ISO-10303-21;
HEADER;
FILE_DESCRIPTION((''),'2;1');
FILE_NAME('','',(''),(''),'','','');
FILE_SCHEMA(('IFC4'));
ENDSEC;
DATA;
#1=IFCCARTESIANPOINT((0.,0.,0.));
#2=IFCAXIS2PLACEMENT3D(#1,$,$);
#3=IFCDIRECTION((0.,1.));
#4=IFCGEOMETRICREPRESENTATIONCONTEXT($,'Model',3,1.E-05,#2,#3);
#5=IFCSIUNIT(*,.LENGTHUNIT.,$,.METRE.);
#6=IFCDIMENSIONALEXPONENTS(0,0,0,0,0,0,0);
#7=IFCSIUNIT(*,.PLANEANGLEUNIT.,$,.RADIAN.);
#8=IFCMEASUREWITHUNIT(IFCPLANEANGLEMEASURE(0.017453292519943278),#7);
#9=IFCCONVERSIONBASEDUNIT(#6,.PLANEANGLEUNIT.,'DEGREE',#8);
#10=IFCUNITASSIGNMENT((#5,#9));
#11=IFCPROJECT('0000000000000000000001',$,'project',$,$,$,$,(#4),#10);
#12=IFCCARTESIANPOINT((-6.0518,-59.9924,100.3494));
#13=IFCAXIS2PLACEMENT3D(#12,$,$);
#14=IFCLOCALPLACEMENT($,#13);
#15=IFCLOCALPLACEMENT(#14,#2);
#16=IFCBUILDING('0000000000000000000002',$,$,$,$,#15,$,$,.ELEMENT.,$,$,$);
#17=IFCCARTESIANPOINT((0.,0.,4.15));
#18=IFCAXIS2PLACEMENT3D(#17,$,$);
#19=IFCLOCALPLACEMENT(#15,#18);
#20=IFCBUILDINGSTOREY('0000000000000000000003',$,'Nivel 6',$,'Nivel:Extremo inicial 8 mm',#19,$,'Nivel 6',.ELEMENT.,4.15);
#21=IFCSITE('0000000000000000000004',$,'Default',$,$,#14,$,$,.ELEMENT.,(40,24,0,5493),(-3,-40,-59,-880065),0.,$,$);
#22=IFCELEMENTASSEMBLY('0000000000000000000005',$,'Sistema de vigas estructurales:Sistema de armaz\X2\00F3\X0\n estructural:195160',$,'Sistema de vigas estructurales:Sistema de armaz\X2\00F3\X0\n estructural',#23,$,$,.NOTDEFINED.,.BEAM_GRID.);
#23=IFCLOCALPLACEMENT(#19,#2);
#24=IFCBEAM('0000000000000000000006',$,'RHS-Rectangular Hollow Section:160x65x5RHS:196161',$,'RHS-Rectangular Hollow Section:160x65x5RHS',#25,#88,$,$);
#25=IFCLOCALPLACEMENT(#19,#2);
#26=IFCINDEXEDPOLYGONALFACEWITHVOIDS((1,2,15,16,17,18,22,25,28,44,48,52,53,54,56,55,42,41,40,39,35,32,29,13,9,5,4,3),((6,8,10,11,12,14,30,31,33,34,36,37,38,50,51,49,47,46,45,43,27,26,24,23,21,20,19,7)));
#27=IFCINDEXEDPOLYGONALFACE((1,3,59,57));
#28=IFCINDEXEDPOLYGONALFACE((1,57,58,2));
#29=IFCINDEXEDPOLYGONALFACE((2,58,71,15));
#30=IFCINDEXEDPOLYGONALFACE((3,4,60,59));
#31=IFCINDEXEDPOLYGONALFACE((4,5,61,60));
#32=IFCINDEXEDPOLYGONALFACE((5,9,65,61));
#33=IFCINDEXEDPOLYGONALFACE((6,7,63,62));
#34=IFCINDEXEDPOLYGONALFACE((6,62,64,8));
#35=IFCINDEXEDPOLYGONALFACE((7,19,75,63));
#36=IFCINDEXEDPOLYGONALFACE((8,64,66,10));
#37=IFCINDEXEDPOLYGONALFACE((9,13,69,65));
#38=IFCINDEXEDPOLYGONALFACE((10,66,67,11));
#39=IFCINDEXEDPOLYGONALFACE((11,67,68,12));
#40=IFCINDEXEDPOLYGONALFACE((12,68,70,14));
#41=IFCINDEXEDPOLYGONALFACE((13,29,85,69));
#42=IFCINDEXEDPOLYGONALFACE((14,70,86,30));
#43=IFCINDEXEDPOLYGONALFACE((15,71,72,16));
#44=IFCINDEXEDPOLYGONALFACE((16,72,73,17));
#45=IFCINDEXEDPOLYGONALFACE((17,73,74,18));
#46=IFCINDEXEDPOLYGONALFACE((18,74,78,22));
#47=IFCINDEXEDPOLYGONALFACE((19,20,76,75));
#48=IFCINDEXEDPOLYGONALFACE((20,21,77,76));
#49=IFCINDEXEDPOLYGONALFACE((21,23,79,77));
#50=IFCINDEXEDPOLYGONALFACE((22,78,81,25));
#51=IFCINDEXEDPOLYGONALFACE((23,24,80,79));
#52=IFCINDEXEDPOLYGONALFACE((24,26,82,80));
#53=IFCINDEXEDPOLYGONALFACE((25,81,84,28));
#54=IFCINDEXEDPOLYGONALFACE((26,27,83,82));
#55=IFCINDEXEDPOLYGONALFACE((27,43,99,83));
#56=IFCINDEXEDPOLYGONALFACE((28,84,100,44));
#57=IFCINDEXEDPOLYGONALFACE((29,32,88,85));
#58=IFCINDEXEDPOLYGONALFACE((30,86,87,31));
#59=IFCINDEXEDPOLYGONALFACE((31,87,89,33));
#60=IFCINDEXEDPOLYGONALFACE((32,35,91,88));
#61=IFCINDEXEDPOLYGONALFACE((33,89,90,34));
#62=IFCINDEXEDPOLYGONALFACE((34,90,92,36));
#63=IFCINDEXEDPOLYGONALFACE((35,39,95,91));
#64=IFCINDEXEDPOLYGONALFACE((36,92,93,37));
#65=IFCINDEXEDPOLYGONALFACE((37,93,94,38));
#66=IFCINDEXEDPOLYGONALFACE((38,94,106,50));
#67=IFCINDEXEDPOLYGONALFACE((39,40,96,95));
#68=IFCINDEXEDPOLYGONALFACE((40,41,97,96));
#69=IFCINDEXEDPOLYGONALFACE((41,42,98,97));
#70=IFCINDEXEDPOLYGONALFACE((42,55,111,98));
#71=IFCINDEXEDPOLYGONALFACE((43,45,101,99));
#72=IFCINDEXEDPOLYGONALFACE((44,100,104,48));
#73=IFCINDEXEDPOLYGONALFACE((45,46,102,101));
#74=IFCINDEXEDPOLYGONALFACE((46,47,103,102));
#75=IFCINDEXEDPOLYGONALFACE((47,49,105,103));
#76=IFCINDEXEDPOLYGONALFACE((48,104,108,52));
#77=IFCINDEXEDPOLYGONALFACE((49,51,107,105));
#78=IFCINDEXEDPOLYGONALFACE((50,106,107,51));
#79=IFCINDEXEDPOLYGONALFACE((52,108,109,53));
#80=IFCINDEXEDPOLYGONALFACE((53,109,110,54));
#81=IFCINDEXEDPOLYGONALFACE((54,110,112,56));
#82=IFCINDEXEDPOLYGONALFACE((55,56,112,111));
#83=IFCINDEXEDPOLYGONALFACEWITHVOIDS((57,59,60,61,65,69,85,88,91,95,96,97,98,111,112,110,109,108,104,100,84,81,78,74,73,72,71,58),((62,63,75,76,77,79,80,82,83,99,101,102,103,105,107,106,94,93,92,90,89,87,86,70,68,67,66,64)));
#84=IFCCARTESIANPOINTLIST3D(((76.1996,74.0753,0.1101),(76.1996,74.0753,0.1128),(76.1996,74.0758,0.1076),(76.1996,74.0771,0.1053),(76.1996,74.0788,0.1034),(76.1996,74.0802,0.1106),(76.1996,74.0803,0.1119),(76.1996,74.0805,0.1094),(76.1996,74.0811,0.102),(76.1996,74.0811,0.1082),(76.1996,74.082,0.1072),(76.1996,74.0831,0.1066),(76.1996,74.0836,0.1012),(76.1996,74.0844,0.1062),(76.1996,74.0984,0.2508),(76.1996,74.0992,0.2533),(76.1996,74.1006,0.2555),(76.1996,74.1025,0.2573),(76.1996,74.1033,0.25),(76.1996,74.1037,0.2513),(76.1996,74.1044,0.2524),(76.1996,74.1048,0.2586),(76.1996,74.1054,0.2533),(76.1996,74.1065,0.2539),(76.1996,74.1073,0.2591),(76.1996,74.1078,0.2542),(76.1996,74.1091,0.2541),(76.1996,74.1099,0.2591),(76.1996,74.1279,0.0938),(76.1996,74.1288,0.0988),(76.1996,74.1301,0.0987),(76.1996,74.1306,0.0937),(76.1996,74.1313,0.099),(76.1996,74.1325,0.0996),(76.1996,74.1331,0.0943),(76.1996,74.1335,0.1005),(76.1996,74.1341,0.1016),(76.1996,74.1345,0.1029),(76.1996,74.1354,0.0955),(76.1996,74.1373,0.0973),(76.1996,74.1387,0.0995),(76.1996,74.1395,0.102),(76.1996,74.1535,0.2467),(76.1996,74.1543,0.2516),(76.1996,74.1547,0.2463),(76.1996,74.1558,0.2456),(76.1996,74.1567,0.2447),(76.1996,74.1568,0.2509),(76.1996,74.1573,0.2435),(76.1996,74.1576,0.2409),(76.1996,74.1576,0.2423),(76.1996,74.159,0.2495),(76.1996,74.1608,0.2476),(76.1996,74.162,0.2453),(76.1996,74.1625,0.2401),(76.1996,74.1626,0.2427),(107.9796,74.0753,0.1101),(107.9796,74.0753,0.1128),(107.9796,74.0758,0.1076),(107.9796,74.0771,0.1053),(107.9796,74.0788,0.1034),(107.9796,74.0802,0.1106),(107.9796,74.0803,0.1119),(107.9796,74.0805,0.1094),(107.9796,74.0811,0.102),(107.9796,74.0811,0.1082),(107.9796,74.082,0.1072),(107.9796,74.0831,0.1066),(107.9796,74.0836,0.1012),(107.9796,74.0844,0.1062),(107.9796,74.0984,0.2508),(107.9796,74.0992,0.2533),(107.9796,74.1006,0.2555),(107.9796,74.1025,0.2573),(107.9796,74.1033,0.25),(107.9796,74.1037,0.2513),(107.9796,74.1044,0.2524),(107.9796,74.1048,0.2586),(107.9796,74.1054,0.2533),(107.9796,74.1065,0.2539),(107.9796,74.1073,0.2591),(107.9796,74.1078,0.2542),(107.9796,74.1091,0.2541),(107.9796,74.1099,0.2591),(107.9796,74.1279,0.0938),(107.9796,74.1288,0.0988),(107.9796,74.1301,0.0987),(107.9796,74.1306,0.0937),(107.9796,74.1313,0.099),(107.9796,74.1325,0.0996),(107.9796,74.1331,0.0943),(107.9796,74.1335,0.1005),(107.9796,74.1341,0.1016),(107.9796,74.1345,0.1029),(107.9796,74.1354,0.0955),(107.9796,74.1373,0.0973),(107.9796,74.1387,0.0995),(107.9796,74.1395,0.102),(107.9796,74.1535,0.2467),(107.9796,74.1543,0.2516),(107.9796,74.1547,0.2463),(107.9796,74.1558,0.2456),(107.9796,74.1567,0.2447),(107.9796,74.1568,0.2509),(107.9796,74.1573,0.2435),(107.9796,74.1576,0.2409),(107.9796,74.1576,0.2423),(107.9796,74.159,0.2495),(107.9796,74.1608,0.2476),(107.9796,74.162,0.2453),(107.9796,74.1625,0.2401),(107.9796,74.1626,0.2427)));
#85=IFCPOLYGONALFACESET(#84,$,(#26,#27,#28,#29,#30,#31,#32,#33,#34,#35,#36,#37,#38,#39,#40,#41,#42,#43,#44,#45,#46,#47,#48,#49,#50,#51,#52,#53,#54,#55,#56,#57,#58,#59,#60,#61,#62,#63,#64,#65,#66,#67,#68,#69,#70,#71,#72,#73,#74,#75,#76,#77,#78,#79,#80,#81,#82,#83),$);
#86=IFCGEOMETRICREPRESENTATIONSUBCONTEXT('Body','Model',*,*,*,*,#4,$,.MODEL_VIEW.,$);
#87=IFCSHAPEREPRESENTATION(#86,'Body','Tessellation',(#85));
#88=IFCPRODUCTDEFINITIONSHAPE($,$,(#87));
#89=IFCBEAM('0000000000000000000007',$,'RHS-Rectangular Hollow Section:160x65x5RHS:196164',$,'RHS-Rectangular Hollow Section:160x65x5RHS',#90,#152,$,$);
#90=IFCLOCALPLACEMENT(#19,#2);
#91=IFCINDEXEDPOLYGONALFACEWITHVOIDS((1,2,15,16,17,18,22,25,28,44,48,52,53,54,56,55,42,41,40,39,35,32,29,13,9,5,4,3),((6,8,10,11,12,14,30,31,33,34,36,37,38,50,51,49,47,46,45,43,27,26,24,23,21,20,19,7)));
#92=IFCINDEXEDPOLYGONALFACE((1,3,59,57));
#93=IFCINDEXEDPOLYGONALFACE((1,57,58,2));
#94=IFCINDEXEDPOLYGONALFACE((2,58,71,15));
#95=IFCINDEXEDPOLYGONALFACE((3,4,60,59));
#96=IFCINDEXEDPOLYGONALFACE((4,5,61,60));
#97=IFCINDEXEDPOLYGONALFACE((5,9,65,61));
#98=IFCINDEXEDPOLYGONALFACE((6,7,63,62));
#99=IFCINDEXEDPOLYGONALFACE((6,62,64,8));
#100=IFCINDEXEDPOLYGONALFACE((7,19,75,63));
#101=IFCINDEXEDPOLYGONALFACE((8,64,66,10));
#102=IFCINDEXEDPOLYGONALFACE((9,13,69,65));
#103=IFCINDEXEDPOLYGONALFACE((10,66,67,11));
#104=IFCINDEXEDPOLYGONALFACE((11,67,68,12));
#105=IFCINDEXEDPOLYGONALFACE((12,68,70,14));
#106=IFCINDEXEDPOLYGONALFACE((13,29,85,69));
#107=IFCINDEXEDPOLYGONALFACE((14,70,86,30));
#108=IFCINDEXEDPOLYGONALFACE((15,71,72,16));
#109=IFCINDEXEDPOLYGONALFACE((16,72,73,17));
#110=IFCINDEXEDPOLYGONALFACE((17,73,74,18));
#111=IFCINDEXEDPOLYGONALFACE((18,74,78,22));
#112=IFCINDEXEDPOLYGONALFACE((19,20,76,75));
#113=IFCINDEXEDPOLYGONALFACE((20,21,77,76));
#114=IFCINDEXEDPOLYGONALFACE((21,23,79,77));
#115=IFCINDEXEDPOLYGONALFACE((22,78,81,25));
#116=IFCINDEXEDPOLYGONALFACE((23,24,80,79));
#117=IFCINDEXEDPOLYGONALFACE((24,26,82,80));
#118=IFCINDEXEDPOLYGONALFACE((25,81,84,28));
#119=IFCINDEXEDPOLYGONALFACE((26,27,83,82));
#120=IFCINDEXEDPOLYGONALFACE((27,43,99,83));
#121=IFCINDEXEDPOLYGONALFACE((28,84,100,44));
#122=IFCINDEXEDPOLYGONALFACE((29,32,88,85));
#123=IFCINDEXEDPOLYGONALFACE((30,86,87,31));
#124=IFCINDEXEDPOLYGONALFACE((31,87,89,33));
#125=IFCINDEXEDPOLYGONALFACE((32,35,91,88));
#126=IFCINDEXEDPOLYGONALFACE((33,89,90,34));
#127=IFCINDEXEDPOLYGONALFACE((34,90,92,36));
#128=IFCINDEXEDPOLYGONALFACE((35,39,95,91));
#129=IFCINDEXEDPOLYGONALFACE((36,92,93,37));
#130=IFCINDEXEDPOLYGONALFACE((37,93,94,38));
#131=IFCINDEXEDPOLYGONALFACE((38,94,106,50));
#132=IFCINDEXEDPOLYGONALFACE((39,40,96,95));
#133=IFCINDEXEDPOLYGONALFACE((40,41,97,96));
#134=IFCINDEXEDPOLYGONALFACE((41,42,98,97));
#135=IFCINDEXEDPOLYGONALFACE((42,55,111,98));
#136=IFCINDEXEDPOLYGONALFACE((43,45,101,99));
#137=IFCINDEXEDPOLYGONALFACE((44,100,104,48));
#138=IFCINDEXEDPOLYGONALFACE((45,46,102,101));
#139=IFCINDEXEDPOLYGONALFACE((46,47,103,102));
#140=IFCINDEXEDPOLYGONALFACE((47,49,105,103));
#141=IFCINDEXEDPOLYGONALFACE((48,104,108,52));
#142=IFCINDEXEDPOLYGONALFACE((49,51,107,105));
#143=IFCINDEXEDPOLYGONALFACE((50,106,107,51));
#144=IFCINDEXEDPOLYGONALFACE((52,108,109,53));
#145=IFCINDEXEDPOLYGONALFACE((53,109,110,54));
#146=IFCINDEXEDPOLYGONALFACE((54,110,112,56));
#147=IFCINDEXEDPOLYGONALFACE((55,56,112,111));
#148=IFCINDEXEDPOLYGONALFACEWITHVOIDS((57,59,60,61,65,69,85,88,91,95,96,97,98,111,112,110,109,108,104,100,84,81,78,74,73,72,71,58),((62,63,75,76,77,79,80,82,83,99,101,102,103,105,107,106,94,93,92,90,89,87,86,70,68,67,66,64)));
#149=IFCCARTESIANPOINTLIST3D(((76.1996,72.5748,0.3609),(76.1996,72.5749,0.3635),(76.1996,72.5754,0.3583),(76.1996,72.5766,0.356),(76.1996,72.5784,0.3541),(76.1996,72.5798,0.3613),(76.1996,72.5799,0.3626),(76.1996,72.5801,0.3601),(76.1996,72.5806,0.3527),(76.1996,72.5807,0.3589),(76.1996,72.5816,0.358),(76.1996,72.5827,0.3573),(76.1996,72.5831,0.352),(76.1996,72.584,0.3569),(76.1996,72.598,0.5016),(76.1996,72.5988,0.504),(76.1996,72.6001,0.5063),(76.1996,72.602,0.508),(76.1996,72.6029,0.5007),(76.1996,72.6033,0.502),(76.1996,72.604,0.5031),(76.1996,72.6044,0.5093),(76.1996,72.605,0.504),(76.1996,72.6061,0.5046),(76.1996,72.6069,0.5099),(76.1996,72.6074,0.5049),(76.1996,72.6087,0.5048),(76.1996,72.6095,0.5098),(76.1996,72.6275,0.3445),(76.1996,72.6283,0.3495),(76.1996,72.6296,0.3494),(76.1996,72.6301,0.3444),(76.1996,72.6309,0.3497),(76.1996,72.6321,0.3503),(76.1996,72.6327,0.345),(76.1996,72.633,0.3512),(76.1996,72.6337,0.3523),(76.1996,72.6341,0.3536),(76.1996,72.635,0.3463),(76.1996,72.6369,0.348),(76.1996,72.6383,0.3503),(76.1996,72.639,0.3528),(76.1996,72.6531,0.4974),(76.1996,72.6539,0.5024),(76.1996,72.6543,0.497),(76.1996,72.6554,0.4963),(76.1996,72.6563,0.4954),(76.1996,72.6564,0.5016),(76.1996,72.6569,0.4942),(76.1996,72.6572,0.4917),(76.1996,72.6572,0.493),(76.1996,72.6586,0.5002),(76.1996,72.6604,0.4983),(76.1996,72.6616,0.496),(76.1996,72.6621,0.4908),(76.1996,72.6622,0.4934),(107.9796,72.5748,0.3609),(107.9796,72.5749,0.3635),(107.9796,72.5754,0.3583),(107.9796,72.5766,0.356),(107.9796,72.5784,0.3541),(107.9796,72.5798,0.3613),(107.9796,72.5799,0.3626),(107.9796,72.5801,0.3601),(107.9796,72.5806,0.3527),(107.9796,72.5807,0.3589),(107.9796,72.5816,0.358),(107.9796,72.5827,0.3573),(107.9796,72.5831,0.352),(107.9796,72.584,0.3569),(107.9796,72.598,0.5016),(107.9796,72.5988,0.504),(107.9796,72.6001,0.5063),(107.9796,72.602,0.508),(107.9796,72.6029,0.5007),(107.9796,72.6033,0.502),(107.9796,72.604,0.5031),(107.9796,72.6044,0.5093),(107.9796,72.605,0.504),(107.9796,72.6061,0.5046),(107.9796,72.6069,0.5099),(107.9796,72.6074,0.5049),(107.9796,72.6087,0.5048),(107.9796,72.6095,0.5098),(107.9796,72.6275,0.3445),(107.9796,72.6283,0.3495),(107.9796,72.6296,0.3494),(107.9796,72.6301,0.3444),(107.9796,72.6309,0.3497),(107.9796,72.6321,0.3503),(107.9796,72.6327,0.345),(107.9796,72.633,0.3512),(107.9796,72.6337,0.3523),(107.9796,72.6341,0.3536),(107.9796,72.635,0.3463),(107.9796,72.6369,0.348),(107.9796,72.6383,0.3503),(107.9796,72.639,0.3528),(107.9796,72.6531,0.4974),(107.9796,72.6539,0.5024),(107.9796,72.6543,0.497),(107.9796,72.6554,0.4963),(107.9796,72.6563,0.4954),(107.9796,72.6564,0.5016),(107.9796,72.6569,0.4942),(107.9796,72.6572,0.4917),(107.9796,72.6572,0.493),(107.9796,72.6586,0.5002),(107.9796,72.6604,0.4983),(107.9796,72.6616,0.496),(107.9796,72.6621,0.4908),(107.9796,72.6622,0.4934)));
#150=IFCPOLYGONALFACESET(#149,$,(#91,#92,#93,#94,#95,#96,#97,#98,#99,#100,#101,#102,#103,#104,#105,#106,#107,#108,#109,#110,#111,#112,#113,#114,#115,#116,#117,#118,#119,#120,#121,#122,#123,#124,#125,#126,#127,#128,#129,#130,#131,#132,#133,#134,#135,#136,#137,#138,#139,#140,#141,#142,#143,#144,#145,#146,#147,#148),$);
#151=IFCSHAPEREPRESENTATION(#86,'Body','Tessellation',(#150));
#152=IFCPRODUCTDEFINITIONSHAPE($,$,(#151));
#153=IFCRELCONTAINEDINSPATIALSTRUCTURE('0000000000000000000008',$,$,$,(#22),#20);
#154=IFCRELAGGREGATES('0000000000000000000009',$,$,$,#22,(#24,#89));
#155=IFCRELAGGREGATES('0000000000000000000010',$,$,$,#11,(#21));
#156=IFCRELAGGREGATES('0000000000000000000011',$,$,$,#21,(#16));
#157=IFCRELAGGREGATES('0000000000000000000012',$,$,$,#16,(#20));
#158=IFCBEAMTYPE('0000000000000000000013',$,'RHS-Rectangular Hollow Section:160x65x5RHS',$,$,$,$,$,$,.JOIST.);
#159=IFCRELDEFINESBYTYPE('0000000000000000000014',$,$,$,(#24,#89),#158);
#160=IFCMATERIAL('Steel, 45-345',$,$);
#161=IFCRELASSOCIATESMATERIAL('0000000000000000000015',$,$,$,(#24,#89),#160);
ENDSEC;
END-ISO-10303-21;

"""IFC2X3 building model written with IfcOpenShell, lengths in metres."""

from ifc_helpers import new_model, entity, si_unit, converted_unit, direction, frame, frame_2d, origin, place, context, subcontext, project, spatial, polyline, circle_curve, parameter, trimmed, segment, composite_curve, outline, extrude, material, type_object, element, aggregate, save


model = new_model("IFC2X3")

# Units and contexts
model_context = context("Model", 3, precision=1e-05, world=origin(), true_north=direction((0.0, 1.0)))
body_context = subcontext(model_context, "Body", "Model", "MODEL_VIEW")
ifc_project = project(units=[si_unit("LENGTHUNIT", "METRE"), converted_unit("PLANEANGLEUNIT", "DEGREE", entity("IfcPlaneAngleMeasure", 0.017453292519943278), si_unit("PLANEANGLEUNIT", "RADIAN"), dimensions=[0, 0, 0, 0, 0, 0, 0])], contexts=[model_context])

# Site, building, storey
site_placement = place(None, frame((-6.0518, -59.9924, 100.3494)))
site = spatial("IfcSite", under=ifc_project, at=site_placement, Name="Default", CompositionType="ELEMENT", RefLatitude=(40, 24, 0, 5493), RefLongitude=(-3, -40, -59, -880065), RefElevation=0.0)
building_placement = place(site_placement, origin())
building = spatial("IfcBuilding", under=site, at=building_placement, CompositionType="ELEMENT")
storey_placement = place(building_placement, frame((0.0, 0.0, 4.15)))
storey = spatial("IfcBuildingStorey", under=building, at=storey_placement, Name="Nivel 6", ObjectType="Nivel:Extremo inicial 8 mm", LongName="Nivel 6", CompositionType="ELEMENT", Elevation=4.15)

# Shared definitions
ifc_material_1 = material(Name="Steel, 45-345")

# Element assembly, beams
assembly_placement = place(storey_placement, origin())
assembly = element("IfcElementAssembly", 1, at=assembly_placement, inside=storey, Name="Sistema de vigas estructurales:Sistema de armazón estructural:195160", ObjectType="Sistema de vigas estructurales:Sistema de armazón estructural", AssemblyPlace="NOTDEFINED", PredefinedType="BEAM_GRID")
beam_type_1 = type_object("IfcBeamType", Name="RHS-Rectangular Hollow Section:160x65x5RHS", PredefinedType="JOIST")
beam_1_placement = place(assembly_placement, frame((107.9796, 74.0794, -0.0603), z_axis=(0.0, 0.0, 1.0), x_axis=(-1.0, 0.0, 0.0)))
beam_1 = element("IfcBeam", 2, at=beam_1_placement, type_object=beam_type_1, material=ifc_material_1, Name="RHS-Rectangular Hollow Section:160x65x5RHS:196161", ObjectType="RHS-Rectangular Hollow Section:160x65x5RHS", context=body_context, shape_type="SweptSolid", body=[
    extrude(outline(composite_curve([segment(trimmed(circle_curve(frame_2d((-0.0225, -0.07), x_axis=(1.0, 0.0)), 0.01), [parameter(180.0)], [parameter(270.0)], True, "PARAMETER"), True, "CONTINUOUS"), segment(polyline([(-0.0225, -0.08), (0.0225, -0.08)]), True, "CONTINUOUS"), segment(trimmed(circle_curve(frame_2d((0.0225, -0.07), x_axis=(1.0, 0.0)), 0.01), [parameter(270.0)], [parameter(0.0)], True, "PARAMETER"), True, "CONTINUOUS"), segment(polyline([(0.0325, -0.07), (0.0325, 0.07)]), True, "CONTINUOUS"), segment(trimmed(circle_curve(frame_2d((0.0225, 0.07), x_axis=(1.0, 0.0)), 0.01), [parameter(360.0)], [parameter(90.0)], True, "PARAMETER"), True, "CONTINUOUS"), segment(polyline([(0.0225, 0.08), (-0.0225, 0.08)]), True, "CONTINUOUS"), segment(trimmed(circle_curve(frame_2d((-0.0225, 0.07), x_axis=(1.0, 0.0)), 0.01), [parameter(90.0)], [parameter(180.0)], True, "PARAMETER"), True, "CONTINUOUS"), segment(polyline([(-0.0325, 0.07), (-0.0325, -0.07)]), True, "CONTINUOUS")], self_intersect=False), holes=[composite_curve([segment(polyline([(0.0225, -0.075), (-0.0225, -0.075)]), True, "CONTINUOUS"), segment(trimmed(circle_curve(frame_2d((-0.0225, -0.07), x_axis=(1.0, 0.0)), 0.005), [parameter(180.0)], [parameter(270.0)], True, "PARAMETER"), False, "CONTINUOUS"), segment(polyline([(-0.0275, -0.07), (-0.0275, 0.07)]), True, "CONTINUOUS"), segment(trimmed(circle_curve(frame_2d((-0.0225, 0.07), x_axis=(1.0, 0.0)), 0.005), [parameter(90.0)], [parameter(180.0)], True, "PARAMETER"), False, "CONTINUOUS"), segment(polyline([(-0.0225, 0.075), (0.0225, 0.075)]), True, "CONTINUOUS"), segment(trimmed(circle_curve(frame_2d((0.0225, 0.07), x_axis=(1.0, 0.0)), 0.005), [parameter(0.0)], [parameter(90.0)], True, "PARAMETER"), False, "CONTINUOUS"), segment(polyline([(0.0275, 0.07), (0.0275, -0.07)]), True, "CONTINUOUS"), segment(trimmed(circle_curve(frame_2d((0.0225, -0.07), x_axis=(1.0, 0.0)), 0.005), [parameter(270.0)], [parameter(0.0)], True, "PARAMETER"), False, "CONTINUOUS")], self_intersect=False)]), frame((0.0, -0.0396, 0.2367), z_axis=(1.0, 0.0, 0.0), x_axis=(0.0, -0.986325, -0.16481)), (0.0, 0.0, 1.0), 31.78),
])
beam_2_placement = place(assembly_placement, frame((107.9796, 72.579, 0.1904), z_axis=(0.0, 0.0, 1.0), x_axis=(-1.0, 0.0, 0.0)))
beam_2 = element("IfcBeam", 3, at=beam_2_placement, type_object=beam_type_1, material=ifc_material_1, Name="RHS-Rectangular Hollow Section:160x65x5RHS:196164", ObjectType="RHS-Rectangular Hollow Section:160x65x5RHS", context=body_context, shape_type="SweptSolid", body=[
    extrude(outline(composite_curve([segment(trimmed(circle_curve(frame_2d((-0.0225, -0.07), x_axis=(1.0, 0.0)), 0.01), [parameter(180.0)], [parameter(270.0)], True, "PARAMETER"), True, "CONTINUOUS"), segment(polyline([(-0.0225, -0.08), (0.0225, -0.08)]), True, "CONTINUOUS"), segment(trimmed(circle_curve(frame_2d((0.0225, -0.07), x_axis=(1.0, 0.0)), 0.01), [parameter(270.0)], [parameter(0.0)], True, "PARAMETER"), True, "CONTINUOUS"), segment(polyline([(0.0325, -0.07), (0.0325, 0.07)]), True, "CONTINUOUS"), segment(trimmed(circle_curve(frame_2d((0.0225, 0.07), x_axis=(1.0, 0.0)), 0.01), [parameter(360.0)], [parameter(90.0)], True, "PARAMETER"), True, "CONTINUOUS"), segment(polyline([(0.0225, 0.08), (-0.0225, 0.08)]), True, "CONTINUOUS"), segment(trimmed(circle_curve(frame_2d((-0.0225, 0.07), x_axis=(1.0, 0.0)), 0.01), [parameter(90.0)], [parameter(180.0)], True, "PARAMETER"), True, "CONTINUOUS"), segment(polyline([(-0.0325, 0.07), (-0.0325, -0.07)]), True, "CONTINUOUS")], self_intersect=False), holes=[composite_curve([segment(polyline([(0.0225, -0.075), (-0.0225, -0.075)]), True, "CONTINUOUS"), segment(trimmed(circle_curve(frame_2d((-0.0225, -0.07), x_axis=(1.0, 0.0)), 0.005), [parameter(180.0)], [parameter(270.0)], True, "PARAMETER"), False, "CONTINUOUS"), segment(polyline([(-0.0275, -0.07), (-0.0275, 0.07)]), True, "CONTINUOUS"), segment(trimmed(circle_curve(frame_2d((-0.0225, 0.07), x_axis=(1.0, 0.0)), 0.005), [parameter(90.0)], [parameter(180.0)], True, "PARAMETER"), False, "CONTINUOUS"), segment(polyline([(-0.0225, 0.075), (0.0225, 0.075)]), True, "CONTINUOUS"), segment(trimmed(circle_curve(frame_2d((0.0225, 0.07), x_axis=(1.0, 0.0)), 0.005), [parameter(0.0)], [parameter(90.0)], True, "PARAMETER"), False, "CONTINUOUS"), segment(polyline([(0.0275, 0.07), (0.0275, -0.07)]), True, "CONTINUOUS"), segment(trimmed(circle_curve(frame_2d((0.0225, -0.07), x_axis=(1.0, 0.0)), 0.005), [parameter(270.0)], [parameter(0.0)], True, "PARAMETER"), False, "CONTINUOUS")], self_intersect=False)]), frame((0.0, -0.0396, 0.2367), z_axis=(1.0, 0.0, 0.0), x_axis=(0.0, -0.986325, -0.16481)), (0.0, 0.0, 1.0), 31.78),
])
aggregate(assembly, [beam_1, beam_2])

save(model, "model.ifc")
